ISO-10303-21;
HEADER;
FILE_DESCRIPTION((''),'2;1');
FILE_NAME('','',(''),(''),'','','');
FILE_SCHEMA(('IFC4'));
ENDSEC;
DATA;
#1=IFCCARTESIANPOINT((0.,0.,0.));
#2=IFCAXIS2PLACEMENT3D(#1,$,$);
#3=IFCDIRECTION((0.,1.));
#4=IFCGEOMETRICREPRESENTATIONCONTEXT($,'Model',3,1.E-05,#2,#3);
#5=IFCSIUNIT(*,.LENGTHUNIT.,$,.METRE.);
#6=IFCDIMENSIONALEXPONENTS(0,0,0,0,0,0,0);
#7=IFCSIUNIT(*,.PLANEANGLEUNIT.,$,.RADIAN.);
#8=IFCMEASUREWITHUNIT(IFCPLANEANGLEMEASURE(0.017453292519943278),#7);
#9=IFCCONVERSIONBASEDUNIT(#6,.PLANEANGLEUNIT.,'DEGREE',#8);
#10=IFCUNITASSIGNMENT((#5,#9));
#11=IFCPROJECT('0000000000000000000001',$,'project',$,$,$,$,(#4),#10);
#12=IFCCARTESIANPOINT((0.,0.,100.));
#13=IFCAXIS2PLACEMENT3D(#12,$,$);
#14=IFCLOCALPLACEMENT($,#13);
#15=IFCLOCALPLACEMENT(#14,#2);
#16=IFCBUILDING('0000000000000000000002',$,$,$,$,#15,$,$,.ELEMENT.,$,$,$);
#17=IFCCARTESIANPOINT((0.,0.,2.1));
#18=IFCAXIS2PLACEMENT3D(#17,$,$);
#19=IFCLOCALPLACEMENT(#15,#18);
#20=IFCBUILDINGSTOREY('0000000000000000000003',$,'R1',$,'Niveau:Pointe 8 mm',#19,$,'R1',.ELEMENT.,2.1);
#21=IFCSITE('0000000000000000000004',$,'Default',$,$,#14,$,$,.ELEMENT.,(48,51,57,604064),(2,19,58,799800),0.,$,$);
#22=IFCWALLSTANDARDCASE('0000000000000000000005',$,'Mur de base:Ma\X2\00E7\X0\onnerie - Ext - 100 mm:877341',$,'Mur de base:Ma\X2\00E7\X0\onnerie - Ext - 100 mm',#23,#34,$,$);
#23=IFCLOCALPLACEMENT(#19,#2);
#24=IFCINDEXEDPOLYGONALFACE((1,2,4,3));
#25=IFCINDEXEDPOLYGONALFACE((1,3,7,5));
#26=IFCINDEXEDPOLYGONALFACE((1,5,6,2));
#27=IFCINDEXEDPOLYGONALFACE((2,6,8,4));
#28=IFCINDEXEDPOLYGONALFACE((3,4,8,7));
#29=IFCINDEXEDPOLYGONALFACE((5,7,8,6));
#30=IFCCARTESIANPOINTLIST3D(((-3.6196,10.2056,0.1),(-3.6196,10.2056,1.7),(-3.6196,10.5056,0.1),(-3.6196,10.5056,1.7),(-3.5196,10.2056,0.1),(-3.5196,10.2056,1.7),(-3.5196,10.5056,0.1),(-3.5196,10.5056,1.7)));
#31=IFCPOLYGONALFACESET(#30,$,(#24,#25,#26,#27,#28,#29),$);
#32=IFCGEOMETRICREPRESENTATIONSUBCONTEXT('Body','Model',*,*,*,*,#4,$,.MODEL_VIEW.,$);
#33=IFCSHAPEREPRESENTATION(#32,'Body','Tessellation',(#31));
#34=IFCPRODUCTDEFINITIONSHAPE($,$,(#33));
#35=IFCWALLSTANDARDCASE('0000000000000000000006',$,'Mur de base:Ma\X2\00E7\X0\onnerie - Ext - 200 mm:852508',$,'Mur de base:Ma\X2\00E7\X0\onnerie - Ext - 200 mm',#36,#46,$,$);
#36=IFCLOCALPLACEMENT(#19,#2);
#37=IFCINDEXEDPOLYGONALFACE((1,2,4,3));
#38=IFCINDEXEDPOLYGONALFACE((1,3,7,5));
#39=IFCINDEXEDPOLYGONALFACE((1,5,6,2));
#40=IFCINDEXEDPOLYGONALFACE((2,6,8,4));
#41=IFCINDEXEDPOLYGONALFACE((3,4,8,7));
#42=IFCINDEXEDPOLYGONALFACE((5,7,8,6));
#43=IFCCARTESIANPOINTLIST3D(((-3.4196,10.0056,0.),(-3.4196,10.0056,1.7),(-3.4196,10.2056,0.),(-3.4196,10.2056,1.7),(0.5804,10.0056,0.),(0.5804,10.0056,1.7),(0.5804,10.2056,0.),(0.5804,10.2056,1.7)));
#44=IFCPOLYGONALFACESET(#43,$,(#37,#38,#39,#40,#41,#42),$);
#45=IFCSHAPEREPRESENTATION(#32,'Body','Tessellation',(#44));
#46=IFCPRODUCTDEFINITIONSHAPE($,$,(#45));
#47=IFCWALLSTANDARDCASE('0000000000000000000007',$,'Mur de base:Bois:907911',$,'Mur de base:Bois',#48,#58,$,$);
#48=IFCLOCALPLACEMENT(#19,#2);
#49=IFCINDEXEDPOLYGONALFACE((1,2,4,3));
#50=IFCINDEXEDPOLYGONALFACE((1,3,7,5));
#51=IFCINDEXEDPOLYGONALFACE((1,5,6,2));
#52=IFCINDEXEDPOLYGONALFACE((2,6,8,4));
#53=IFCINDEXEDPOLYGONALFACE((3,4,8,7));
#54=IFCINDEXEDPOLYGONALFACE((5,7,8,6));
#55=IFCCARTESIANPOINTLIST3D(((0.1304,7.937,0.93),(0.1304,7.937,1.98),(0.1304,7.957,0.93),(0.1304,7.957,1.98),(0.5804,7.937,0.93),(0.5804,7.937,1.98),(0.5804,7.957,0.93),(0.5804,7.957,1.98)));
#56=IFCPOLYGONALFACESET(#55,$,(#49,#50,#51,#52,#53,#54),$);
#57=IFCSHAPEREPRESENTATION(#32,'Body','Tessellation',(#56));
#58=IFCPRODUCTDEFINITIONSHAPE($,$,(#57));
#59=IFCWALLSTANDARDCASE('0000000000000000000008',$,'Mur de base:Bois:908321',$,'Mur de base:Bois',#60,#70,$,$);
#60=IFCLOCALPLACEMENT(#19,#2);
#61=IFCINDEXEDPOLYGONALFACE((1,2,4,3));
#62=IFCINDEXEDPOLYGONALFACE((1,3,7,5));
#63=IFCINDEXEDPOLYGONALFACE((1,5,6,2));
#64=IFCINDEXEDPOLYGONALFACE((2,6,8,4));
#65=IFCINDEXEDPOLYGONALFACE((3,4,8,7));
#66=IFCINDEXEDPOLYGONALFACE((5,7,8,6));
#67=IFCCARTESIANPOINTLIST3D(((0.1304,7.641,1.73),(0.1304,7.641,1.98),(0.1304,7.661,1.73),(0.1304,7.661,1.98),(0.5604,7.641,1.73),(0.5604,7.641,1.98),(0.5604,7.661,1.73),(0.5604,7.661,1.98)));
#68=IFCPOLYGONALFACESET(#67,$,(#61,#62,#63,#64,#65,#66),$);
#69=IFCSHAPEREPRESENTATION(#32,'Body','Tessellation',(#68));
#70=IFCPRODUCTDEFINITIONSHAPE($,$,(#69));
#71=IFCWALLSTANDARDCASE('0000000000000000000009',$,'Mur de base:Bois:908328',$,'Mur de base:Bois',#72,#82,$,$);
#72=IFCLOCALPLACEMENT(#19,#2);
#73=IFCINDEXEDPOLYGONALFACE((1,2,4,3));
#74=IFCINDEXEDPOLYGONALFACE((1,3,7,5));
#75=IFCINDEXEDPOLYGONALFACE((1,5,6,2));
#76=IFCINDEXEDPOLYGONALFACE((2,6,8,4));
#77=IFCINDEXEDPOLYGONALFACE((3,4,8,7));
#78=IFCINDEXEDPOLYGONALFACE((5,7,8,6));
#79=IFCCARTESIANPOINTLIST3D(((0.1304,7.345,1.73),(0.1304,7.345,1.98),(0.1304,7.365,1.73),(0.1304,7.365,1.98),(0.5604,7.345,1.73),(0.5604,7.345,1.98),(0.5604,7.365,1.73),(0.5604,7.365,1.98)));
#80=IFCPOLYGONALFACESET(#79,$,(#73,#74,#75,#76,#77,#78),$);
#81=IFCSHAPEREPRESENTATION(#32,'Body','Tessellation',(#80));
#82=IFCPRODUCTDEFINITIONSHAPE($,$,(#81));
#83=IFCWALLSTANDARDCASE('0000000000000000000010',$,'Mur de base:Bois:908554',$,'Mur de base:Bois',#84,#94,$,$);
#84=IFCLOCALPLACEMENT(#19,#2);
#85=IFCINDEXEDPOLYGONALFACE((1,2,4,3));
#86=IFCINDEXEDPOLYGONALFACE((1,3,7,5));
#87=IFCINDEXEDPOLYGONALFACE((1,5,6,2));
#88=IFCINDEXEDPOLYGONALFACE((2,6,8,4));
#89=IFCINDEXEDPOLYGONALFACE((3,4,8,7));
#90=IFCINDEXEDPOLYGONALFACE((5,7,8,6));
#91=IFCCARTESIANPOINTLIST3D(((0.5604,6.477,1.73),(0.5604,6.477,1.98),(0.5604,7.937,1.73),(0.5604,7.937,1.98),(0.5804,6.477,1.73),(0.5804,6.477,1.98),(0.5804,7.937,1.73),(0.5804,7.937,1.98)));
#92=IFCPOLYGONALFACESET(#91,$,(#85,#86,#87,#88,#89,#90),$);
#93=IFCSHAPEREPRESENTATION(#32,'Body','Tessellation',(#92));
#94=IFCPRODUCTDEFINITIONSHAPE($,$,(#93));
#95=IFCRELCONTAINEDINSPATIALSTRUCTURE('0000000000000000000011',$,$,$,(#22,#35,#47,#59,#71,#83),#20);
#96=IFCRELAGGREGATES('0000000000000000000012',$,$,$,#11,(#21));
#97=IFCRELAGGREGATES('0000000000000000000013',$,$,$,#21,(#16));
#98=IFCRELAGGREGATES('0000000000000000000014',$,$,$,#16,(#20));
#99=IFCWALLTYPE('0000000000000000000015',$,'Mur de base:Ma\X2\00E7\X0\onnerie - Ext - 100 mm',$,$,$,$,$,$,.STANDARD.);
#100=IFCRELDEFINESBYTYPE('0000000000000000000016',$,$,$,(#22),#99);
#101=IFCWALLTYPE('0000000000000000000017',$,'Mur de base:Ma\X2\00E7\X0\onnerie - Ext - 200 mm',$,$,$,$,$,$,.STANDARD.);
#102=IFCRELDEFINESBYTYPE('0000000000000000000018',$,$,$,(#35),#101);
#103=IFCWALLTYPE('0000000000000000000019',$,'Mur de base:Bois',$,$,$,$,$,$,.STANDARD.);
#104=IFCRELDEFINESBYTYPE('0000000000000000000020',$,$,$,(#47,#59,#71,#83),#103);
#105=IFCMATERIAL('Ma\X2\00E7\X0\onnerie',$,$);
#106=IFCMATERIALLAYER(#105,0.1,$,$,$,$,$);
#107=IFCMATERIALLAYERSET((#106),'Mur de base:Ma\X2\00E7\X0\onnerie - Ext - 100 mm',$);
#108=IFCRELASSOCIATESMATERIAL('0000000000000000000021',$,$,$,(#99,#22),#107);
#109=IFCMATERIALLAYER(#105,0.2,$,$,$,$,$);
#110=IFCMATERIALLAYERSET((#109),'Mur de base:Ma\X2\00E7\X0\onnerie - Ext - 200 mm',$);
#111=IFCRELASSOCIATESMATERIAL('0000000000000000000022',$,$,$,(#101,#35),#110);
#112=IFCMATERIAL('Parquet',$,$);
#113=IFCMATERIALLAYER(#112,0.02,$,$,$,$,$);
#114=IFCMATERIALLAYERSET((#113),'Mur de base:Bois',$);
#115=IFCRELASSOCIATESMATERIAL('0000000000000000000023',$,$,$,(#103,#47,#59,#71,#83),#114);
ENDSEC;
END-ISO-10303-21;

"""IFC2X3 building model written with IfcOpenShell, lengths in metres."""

from ifc_helpers import new_model, entity, si_unit, converted_unit, direction, frame, frame_2d, origin, place, context, subcontext, project, spatial, polyline, rectangle, extrude, clip, bounded_halfspace, material, layer, layer_set, layer_usage, type_object, element, save


model = new_model("IFC2X3")

# Units and contexts
model_context = context("Model", 3, precision=1e-05, world=origin(), true_north=direction((0.0, 1.0)))
body_context = subcontext(model_context, "Body", "Model", "MODEL_VIEW")
ifc_project = project(units=[si_unit("LENGTHUNIT", "METRE"), converted_unit("PLANEANGLEUNIT", "DEGREE", entity("IfcPlaneAngleMeasure", 0.017453292519943278), si_unit("PLANEANGLEUNIT", "RADIAN"), dimensions=[0, 0, 0, 0, 0, 0, 0])], contexts=[model_context])

# Site, building, storey
site_placement = place(None, frame((0.0, 0.0, 100.0)))
site = spatial("IfcSite", under=ifc_project, at=site_placement, Name="Default", CompositionType="ELEMENT", RefLatitude=(48, 51, 57, 604064), RefLongitude=(2, 19, 58, 799800), RefElevation=0.0)
building_placement = place(site_placement, origin())
building = spatial("IfcBuilding", under=site, at=building_placement, CompositionType="ELEMENT")
storey_placement = place(building_placement, frame((0.0, 0.0, 2.1)))
storey = spatial("IfcBuildingStorey", under=building, at=storey_placement, Name="R1", ObjectType="Niveau:Pointe 8 mm", LongName="R1", CompositionType="ELEMENT", Elevation=2.1)

# Walls
ifc_material_1 = material(Name="Maçonnerie")
ifc_layer_1 = layer(ifc_material_1, 0.1)
ifc_layer_set_1 = layer_set([ifc_layer_1], Name="Mur de base:Maçonnerie - Ext - 100 mm")
wall_type_1 = type_object("IfcWallType", Name="Mur de base:Maçonnerie - Ext - 100 mm", PredefinedType="STANDARD", material=ifc_layer_set_1)
ifc_layer_usage_1 = layer_usage(ifc_layer_set_1, "AXIS2", "NEGATIVE", 0.05)
wall_1_placement = place(storey_placement, frame((-3.5696, 10.2056, 0.1), z_axis=(0.0, 0.0, 1.0), x_axis=(0.0, 1.0, 0.0)))
element("IfcWallStandardCase", 1, at=wall_1_placement, inside=storey, type_object=wall_type_1, material=ifc_layer_usage_1, Name="Mur de base:Maçonnerie - Ext - 100 mm:877341", ObjectType="Mur de base:Maçonnerie - Ext - 100 mm", context=body_context, shape_type="Clipping", body=[
    clip(extrude(rectangle(XDim=0.3, YDim=0.1, at=frame_2d((0.15, 0.0), x_axis=(-1.0, 0.0))), origin(), (0.0, 0.0, 1.0), 1.6), bounded_halfspace(frame((0.0, -0.05, 0.0), z_axis=(1.0, 0.0, 0.0), x_axis=(0.0, 0.0, -1.0)), True, frame((0.0, -0.05, 0.0), z_axis=(1.0, 0.0, 0.0), x_axis=(0.0, 0.0, -1.0)), polyline([(0.0, 0.0), (0.0, 0.1), (-1.6, 0.1), (-1.6, 0.0), (0.0, 0.0)]))),
])
ifc_layer_2 = layer(ifc_material_1, 0.2)
ifc_layer_set_2 = layer_set([ifc_layer_2], Name="Mur de base:Maçonnerie - Ext - 200 mm")
ifc_layer_usage_2 = layer_usage(ifc_layer_set_2, "AXIS2", "NEGATIVE", 0.1)
wall_type_2 = type_object("IfcWallType", Name="Mur de base:Maçonnerie - Ext - 200 mm", PredefinedType="STANDARD", material=ifc_layer_set_2)
wall_2_placement = place(storey_placement, frame((-3.4196, 10.1056, 0.0)))
element("IfcWallStandardCase", 2, at=wall_2_placement, inside=storey, type_object=wall_type_2, material=ifc_layer_usage_2, Name="Mur de base:Maçonnerie - Ext - 200 mm:852508", ObjectType="Mur de base:Maçonnerie - Ext - 200 mm", context=body_context, shape_type="SweptSolid", body=[
    extrude(rectangle(XDim=4.0, YDim=0.2, at=frame_2d((2.0, 0.0), x_axis=(-1.0, 0.0))), origin(), (0.0, 0.0, 1.0), 1.7),
])
ifc_material_2 = material(Name="Parquet")
ifc_layer_3 = layer(ifc_material_2, 0.02)
ifc_layer_set_3 = layer_set([ifc_layer_3], Name="Mur de base:Bois")
ifc_layer_usage_3 = layer_usage(ifc_layer_set_3, "AXIS2", "NEGATIVE", 0.01)
wall_type_3 = type_object("IfcWallType", Name="Mur de base:Bois", PredefinedType="STANDARD", material=ifc_layer_set_3)
wall_3_placement = place(storey_placement, frame((0.5804, 7.947, 0.93), z_axis=(0.0, 0.0, 1.0), x_axis=(-1.0, 0.0, 0.0)))
element("IfcWallStandardCase", 3, at=wall_3_placement, inside=storey, type_object=wall_type_3, material=ifc_layer_usage_3, Name="Mur de base:Bois:907911", ObjectType="Mur de base:Bois", context=body_context, shape_type="SweptSolid", body=[
    extrude(rectangle(XDim=0.45, YDim=0.02, at=frame_2d((0.225, 0.0), x_axis=(-1.0, 0.0))), origin(), (0.0, 0.0, 1.0), 1.05),
])
ifc_layer_usage_4 = layer_usage(ifc_layer_set_3, "AXIS2", "NEGATIVE", 0.01)
wall_4_placement = place(storey_placement, frame((0.5604, 7.651, 1.73), z_axis=(0.0, 0.0, 1.0), x_axis=(-1.0, 0.0, 0.0)))
element("IfcWallStandardCase", 4, at=wall_4_placement, inside=storey, type_object=wall_type_3, material=ifc_layer_usage_4, Name="Mur de base:Bois:908321", ObjectType="Mur de base:Bois", context=body_context, shape_type="SweptSolid", body=[
    extrude(rectangle(XDim=0.43, YDim=0.02, at=frame_2d((0.215, 0.0), x_axis=(-1.0, 0.0))), origin(), (0.0, 0.0, 1.0), 0.25),
])
ifc_layer_usage_5 = layer_usage(ifc_layer_set_3, "AXIS2", "NEGATIVE", 0.01)
wall_5_placement = place(storey_placement, frame((0.5604, 7.355, 1.73), z_axis=(0.0, 0.0, 1.0), x_axis=(-1.0, 0.0, 0.0)))
element("IfcWallStandardCase", 5, at=wall_5_placement, inside=storey, type_object=wall_type_3, material=ifc_layer_usage_5, Name="Mur de base:Bois:908328", ObjectType="Mur de base:Bois", context=body_context, shape_type="SweptSolid", body=[
    extrude(rectangle(XDim=0.43, YDim=0.02, at=frame_2d((0.215, 0.0), x_axis=(-1.0, 0.0))), origin(), (0.0, 0.0, 1.0), 0.25),
])
ifc_layer_usage_6 = layer_usage(ifc_layer_set_3, "AXIS2", "NEGATIVE", 0.01)
wall_6_placement = place(storey_placement, frame((0.5704, 7.937, 1.73), z_axis=(0.0, 0.0, 1.0), x_axis=(0.0, -1.0, 0.0)))
element("IfcWallStandardCase", 6, at=wall_6_placement, inside=storey, type_object=wall_type_3, material=ifc_layer_usage_6, Name="Mur de base:Bois:908554", ObjectType="Mur de base:Bois", context=body_context, shape_type="SweptSolid", body=[
    extrude(rectangle(XDim=1.46, YDim=0.02, at=frame_2d((0.73, 0.0), x_axis=(-1.0, 0.0))), origin(), (0.0, 0.0, 1.0), 0.25),
])

save(model, "model.ifc")
